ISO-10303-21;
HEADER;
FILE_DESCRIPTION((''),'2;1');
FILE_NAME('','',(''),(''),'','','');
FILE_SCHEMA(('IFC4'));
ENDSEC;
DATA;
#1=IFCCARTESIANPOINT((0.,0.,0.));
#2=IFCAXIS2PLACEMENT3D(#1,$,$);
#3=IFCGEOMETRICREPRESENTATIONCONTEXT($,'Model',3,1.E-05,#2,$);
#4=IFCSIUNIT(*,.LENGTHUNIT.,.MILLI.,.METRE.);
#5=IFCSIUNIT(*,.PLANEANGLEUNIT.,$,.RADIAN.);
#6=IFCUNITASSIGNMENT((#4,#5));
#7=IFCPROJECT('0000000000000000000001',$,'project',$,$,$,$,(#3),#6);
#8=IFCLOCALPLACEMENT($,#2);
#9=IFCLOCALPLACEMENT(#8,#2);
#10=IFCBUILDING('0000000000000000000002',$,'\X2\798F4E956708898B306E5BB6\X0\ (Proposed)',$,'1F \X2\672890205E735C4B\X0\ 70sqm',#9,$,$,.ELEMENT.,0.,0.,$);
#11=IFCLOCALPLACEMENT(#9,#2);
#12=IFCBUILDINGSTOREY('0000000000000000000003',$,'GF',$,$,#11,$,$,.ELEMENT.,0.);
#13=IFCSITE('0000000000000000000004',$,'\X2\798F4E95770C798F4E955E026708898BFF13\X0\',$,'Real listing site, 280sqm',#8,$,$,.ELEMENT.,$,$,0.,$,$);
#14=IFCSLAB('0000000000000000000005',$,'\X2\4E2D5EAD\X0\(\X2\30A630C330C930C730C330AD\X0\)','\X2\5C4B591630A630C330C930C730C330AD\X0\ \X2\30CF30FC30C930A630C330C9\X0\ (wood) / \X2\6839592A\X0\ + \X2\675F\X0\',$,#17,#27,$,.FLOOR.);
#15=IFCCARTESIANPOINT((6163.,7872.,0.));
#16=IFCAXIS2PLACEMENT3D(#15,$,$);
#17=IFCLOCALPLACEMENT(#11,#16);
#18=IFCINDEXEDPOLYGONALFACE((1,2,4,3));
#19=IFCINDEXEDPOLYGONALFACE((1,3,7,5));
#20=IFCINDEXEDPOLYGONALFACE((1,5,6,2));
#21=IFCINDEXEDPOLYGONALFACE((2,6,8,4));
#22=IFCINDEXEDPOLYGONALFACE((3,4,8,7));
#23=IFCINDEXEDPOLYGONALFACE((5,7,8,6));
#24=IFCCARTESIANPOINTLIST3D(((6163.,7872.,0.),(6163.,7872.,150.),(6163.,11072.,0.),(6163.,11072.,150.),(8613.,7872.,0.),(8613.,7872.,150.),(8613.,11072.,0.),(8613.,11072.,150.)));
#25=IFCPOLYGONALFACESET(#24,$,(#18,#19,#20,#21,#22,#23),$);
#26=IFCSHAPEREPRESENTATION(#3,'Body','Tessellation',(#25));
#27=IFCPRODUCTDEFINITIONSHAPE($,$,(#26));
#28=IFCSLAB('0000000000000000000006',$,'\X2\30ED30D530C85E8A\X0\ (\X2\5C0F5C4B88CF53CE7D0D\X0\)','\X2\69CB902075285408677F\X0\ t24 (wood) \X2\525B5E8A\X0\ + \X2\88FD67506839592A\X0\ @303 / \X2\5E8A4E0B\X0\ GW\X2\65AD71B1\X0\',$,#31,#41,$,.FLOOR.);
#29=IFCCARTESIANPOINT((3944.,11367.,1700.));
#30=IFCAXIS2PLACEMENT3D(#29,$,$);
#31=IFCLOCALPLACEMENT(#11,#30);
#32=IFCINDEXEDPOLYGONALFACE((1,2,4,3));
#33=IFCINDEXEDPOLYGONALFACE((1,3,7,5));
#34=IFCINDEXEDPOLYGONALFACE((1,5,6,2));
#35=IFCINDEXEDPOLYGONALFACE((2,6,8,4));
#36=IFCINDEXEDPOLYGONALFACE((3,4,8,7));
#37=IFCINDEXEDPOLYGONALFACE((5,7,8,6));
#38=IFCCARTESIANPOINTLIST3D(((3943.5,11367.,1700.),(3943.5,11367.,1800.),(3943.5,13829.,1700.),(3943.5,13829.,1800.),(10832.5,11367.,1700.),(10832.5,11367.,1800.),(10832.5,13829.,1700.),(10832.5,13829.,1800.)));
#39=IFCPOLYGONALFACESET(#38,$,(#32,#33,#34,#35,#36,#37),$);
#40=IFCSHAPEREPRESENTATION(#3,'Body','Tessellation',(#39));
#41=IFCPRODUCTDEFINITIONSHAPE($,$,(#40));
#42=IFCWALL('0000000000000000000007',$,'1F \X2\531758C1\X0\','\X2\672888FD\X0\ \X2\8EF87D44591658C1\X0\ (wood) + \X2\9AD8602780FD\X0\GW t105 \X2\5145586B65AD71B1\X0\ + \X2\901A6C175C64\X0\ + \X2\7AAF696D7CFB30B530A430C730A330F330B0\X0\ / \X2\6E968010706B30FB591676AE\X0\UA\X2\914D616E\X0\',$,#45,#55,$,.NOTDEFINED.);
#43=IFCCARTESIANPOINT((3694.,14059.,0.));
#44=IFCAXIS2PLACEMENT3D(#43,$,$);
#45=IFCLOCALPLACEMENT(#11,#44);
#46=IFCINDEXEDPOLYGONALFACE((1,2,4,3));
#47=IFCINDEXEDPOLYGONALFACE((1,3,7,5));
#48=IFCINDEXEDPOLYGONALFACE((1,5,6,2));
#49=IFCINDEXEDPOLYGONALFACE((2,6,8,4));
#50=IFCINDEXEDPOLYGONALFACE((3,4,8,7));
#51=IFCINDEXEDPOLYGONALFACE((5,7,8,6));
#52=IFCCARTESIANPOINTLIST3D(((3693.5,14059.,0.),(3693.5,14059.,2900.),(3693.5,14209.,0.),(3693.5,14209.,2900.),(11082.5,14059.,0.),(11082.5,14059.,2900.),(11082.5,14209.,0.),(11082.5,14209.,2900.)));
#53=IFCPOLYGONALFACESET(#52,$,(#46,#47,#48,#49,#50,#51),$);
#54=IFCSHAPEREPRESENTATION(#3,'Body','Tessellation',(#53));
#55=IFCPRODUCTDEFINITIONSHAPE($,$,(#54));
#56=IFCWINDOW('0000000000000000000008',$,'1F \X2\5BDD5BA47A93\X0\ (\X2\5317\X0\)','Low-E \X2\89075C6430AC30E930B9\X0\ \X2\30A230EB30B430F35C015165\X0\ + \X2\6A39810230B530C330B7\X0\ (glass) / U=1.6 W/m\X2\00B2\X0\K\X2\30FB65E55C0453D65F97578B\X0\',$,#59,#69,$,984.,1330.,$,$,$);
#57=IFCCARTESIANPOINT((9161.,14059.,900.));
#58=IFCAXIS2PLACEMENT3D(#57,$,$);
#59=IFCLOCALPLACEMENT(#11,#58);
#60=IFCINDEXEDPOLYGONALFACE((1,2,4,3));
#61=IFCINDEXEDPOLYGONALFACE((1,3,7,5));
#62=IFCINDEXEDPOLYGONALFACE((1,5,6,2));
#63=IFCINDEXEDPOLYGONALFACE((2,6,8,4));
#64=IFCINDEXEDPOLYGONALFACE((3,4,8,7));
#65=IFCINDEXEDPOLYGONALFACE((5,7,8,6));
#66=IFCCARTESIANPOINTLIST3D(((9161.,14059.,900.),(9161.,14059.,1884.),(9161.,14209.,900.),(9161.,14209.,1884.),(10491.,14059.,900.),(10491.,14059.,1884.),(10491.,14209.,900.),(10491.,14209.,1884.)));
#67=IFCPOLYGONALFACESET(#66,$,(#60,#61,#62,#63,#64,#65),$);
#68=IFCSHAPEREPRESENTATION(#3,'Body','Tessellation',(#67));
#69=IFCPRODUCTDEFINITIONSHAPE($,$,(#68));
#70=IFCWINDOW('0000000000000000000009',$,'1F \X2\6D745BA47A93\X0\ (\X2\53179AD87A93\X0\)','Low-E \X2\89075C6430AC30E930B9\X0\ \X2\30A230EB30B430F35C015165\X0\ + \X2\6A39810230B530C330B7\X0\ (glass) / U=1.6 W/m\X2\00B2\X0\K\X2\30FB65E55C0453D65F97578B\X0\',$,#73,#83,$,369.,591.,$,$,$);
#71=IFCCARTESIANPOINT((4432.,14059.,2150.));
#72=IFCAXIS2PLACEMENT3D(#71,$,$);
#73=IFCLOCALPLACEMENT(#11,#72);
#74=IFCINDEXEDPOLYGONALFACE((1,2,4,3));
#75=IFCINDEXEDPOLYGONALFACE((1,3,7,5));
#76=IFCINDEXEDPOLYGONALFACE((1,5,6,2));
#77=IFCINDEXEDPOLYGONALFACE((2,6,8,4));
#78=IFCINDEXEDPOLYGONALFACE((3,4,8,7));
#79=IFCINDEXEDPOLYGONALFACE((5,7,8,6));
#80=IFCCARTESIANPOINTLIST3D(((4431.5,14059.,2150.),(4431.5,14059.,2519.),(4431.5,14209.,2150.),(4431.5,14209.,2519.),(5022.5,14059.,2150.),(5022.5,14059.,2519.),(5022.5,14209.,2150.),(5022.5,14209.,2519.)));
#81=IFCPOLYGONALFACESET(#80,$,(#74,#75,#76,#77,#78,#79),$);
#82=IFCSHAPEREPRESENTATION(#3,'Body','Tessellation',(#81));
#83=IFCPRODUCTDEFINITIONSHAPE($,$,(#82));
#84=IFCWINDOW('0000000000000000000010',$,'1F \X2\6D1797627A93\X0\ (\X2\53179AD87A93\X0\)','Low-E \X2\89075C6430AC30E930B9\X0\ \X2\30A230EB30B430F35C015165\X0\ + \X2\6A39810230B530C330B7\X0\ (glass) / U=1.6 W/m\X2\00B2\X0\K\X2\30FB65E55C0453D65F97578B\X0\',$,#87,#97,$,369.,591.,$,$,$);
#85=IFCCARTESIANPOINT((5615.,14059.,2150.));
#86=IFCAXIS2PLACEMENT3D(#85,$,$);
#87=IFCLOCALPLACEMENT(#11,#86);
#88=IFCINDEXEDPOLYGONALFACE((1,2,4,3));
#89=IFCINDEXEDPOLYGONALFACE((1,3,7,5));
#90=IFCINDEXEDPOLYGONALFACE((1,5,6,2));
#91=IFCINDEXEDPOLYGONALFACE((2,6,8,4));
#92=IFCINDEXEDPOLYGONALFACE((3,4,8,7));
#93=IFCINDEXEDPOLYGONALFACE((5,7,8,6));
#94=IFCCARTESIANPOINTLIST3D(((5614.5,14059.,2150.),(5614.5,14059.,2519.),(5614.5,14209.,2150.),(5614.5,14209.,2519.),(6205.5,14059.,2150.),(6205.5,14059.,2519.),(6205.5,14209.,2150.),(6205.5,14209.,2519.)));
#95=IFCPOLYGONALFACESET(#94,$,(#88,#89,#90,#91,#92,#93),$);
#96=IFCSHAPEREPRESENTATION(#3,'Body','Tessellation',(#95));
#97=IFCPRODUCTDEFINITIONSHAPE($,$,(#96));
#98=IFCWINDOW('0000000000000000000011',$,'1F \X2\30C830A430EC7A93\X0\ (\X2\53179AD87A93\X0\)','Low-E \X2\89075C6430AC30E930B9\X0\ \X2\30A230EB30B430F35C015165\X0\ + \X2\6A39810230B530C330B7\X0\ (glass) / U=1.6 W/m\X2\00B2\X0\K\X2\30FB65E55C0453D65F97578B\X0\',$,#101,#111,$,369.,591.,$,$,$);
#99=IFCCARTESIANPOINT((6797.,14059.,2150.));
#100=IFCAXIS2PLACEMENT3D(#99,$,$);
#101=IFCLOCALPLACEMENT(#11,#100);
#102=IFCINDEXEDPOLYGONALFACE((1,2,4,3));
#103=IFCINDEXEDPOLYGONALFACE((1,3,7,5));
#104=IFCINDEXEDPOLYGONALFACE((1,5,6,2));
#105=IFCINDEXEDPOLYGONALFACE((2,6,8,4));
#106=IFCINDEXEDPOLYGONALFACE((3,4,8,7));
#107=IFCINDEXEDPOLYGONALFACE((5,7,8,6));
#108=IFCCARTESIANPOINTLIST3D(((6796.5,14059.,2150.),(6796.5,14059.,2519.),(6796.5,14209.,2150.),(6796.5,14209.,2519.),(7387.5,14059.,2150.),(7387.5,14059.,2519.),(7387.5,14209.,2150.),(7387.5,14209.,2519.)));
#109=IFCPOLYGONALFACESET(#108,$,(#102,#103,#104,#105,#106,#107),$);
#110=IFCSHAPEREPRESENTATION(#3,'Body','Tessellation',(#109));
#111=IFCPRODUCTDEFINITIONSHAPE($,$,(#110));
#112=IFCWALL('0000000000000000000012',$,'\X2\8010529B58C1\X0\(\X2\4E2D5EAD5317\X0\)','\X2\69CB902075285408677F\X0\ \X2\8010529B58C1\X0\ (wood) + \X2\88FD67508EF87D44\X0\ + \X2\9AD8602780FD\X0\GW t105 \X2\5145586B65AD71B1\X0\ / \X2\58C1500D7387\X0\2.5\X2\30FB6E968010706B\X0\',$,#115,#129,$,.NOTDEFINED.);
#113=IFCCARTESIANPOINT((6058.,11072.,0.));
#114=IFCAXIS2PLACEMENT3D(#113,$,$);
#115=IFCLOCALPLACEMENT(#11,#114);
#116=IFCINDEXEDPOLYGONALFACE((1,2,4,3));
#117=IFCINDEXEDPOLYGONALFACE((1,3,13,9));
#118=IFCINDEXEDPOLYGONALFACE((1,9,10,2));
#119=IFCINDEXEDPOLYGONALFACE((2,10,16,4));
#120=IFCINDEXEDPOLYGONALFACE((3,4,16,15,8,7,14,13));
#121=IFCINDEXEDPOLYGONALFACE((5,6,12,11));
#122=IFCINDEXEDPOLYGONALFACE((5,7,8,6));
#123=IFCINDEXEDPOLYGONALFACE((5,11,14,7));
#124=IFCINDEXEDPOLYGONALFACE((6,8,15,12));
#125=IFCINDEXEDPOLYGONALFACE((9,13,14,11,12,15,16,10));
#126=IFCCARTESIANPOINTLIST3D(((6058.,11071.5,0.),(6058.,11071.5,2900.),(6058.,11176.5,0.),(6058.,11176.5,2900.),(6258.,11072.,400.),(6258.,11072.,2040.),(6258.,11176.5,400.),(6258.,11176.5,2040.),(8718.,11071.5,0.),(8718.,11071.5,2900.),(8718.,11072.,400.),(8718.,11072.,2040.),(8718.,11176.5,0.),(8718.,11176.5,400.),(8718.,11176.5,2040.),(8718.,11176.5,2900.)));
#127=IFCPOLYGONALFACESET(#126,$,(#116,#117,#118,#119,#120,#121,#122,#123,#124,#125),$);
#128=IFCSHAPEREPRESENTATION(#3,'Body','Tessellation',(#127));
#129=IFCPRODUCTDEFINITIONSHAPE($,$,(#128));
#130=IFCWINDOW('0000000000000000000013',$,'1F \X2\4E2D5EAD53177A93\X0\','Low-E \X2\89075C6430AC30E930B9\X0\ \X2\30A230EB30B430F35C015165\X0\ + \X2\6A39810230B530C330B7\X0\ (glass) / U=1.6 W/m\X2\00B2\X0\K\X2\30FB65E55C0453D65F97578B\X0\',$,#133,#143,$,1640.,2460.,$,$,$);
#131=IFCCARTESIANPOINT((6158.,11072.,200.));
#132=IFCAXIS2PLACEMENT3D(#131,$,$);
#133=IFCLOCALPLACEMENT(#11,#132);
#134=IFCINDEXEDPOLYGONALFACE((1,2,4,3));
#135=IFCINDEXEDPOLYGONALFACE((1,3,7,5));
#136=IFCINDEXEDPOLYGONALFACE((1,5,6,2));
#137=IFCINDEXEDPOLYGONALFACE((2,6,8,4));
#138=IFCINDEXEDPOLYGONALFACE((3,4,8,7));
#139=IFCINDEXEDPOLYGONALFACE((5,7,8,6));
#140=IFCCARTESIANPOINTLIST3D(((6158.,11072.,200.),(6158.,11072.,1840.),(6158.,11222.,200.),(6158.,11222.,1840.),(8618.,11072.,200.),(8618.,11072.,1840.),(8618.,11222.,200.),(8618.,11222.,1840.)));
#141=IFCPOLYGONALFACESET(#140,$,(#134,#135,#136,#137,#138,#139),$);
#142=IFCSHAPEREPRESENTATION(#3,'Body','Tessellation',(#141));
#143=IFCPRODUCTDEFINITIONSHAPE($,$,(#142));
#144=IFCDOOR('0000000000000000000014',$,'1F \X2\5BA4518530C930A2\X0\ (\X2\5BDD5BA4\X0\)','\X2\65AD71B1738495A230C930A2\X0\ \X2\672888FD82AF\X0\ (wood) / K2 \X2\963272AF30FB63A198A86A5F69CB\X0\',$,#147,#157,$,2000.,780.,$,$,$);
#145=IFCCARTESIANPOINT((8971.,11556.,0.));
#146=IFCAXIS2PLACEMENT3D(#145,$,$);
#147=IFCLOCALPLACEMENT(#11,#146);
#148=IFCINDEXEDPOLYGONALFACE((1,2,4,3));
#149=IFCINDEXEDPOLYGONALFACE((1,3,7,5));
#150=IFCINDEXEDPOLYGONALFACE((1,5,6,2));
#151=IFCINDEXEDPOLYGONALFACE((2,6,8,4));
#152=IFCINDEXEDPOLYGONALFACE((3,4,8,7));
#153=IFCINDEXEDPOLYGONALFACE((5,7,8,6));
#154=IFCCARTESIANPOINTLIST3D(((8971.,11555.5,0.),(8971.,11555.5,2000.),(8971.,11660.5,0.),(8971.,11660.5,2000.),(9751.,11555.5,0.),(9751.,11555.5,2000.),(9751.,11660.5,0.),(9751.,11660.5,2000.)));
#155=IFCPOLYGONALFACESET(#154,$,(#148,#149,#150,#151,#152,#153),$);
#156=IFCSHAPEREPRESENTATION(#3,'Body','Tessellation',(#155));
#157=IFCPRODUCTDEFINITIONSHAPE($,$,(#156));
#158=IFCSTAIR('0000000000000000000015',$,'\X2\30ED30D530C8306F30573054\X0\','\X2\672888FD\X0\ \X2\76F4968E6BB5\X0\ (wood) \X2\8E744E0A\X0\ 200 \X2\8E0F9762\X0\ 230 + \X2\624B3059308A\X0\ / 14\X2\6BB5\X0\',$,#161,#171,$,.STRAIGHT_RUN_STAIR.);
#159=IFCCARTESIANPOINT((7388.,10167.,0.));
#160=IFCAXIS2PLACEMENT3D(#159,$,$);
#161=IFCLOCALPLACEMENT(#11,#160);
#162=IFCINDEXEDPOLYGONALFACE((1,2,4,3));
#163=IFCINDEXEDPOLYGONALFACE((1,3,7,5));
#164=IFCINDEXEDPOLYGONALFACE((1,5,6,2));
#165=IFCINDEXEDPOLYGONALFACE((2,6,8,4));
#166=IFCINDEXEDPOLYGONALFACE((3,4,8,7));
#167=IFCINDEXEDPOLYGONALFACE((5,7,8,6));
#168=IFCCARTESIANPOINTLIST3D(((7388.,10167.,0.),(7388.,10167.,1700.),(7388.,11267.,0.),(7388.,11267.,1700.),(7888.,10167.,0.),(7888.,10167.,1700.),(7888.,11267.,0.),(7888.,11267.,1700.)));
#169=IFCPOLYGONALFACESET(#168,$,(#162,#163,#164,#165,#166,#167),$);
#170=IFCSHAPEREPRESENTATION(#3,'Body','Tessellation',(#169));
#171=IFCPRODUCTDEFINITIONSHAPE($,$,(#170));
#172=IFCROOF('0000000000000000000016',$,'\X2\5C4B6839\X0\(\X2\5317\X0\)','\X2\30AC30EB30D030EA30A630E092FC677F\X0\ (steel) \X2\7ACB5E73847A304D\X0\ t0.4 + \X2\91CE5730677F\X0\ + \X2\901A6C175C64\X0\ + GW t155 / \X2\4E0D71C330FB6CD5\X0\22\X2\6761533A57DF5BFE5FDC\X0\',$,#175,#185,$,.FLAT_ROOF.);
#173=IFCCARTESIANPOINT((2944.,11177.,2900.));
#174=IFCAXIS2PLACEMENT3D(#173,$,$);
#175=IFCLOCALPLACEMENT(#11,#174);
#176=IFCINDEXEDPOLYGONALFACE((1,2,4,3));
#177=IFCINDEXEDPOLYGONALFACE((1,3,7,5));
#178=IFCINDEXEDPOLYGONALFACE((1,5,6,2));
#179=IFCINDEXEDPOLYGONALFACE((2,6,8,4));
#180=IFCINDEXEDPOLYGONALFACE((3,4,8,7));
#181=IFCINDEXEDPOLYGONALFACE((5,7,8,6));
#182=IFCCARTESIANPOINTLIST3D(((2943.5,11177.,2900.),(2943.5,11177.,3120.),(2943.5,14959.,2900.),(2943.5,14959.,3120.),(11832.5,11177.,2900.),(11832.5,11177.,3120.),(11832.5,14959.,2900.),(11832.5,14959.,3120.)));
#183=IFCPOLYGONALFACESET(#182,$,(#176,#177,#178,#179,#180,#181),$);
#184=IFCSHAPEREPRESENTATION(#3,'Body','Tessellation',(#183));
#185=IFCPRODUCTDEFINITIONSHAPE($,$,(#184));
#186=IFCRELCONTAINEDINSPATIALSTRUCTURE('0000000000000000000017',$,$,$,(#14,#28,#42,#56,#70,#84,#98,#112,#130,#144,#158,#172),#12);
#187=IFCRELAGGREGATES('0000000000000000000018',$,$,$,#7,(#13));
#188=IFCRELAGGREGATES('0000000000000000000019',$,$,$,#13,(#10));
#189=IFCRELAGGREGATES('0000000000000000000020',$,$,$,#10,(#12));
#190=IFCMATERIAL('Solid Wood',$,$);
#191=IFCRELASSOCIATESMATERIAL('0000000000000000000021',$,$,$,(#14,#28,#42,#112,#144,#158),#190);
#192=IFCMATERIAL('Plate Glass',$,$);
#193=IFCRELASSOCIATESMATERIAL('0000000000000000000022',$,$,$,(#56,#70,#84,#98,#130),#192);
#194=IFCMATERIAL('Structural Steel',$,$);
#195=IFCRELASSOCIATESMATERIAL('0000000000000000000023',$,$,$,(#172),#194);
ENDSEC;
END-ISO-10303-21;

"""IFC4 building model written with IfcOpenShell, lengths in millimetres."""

from ifc_helpers import new_model, si_unit, frame, frame_2d, origin, place, context, project, spatial, rectangle, extrude, material, element, fill, save


model = new_model("IFC4")

# Units and contexts
model_context = context("Model", 3, precision=1e-05, world=origin())
ifc_project = project(units=[si_unit("LENGTHUNIT", "METRE", prefix="MILLI"), si_unit("PLANEANGLEUNIT", "RADIAN")], contexts=[model_context])

# Site, building, storey
site_placement = place(None, origin())
site = spatial("IfcSite", under=ifc_project, at=site_placement, Name="福井県福井市月見３", ObjectType="Real listing site, 280sqm", CompositionType="ELEMENT", RefElevation=0.0)
building_placement = place(site_placement, origin())
building = spatial("IfcBuilding", under=site, at=building_placement, Name="福井月見の家 (Proposed)", ObjectType="1F 木造平屋 70sqm", CompositionType="ELEMENT", ElevationOfRefHeight=0.0, ElevationOfTerrain=0.0)
storey_placement = place(building_placement, origin())
storey = spatial("IfcBuildingStorey", under=building, at=storey_placement, Name="GF", CompositionType="ELEMENT", Elevation=0.0)

# Slabs
ifc_material_1 = material(Name="Solid Wood")
slab_1_placement = place(storey_placement, frame((6163.0, 7872.0, 0.0)))
element("IfcSlab", 1, at=slab_1_placement, inside=storey, material=ifc_material_1, Name="中庭(ウッドデッキ)", Description="屋外ウッドデッキ ハードウッド (wood) / 根太 + 束", PredefinedType="FLOOR", context=model_context, shape_type="SweptSolid", body=[
    extrude(rectangle(XDim=2450.0, YDim=3200.0, at=frame_2d((1225.0, 1600.0))), frame((6163.0, 7872.0, 0.0)), (0.0, 0.0, 1.0), 150.0),
])
slab_2_placement = place(storey_placement, frame((3944.0, 11367.0, 1700.0)))
element("IfcSlab", 2, at=slab_2_placement, inside=storey, material=ifc_material_1, Name="ロフト床 (小屋裏収納)", Description="構造用合板 t24 (wood) 剛床 + 製材根太 @303 / 床下 GW断熱", PredefinedType="FLOOR", context=model_context, shape_type="SweptSolid", body=[
    extrude(rectangle(XDim=6889.0, YDim=2462.0, at=frame_2d((3444.0, 1231.0))), frame((3944.0, 11367.0, 1700.0)), (0.0, 0.0, 1.0), 100.0),
])

# Wall, openings, windows
wall_1_placement = place(storey_placement, frame((3694.0, 14059.0, 0.0)))
wall_1 = element("IfcWall", 3, at=wall_1_placement, inside=storey, material=ifc_material_1, Name="1F 北壁", Description="木製 軸組外壁 (wood) + 高性能GW t105 充填断熱 + 通気層 + 窯業系サイディング / 準耐火・外皮UA配慮", PredefinedType="NOTDEFINED", context=model_context, shape_type="SweptSolid", body=[
    extrude(rectangle(XDim=7389.0, YDim=150.0, at=frame_2d((3694.0, 75.0))), frame((3694.0, 14059.0, 0.0)), (0.0, 0.0, 1.0), 2900.0),
])
opening_1_placement = place(storey_placement, frame((9161.0, 14059.0, 900.0)))
opening_1 = element("IfcOpeningElement", 4, at=opening_1_placement, cuts=wall_1, PredefinedType="NOTDEFINED", context=model_context, shape_type="SweptSolid", body=[
    extrude(rectangle(XDim=1330.0, YDim=150.0, at=frame_2d((665.0, 75.0))), frame((9161.0, 14059.0, 900.0)), (0.0, 0.0, 1.0), 984.0),
])
opening_2_placement = place(storey_placement, frame((4432.0, 14059.0, 2150.0)))
opening_2 = element("IfcOpeningElement", 5, at=opening_2_placement, cuts=wall_1, PredefinedType="NOTDEFINED", context=model_context, shape_type="SweptSolid", body=[
    extrude(rectangle(XDim=591.0, YDim=150.0, at=frame_2d((295.0, 75.0))), frame((4432.0, 14059.0, 2150.0)), (0.0, 0.0, 1.0), 369.0),
])
opening_3_placement = place(storey_placement, frame((5615.0, 14059.0, 2150.0)))
opening_3 = element("IfcOpeningElement", 6, at=opening_3_placement, cuts=wall_1, PredefinedType="NOTDEFINED", context=model_context, shape_type="SweptSolid", body=[
    extrude(rectangle(XDim=591.0, YDim=150.0, at=frame_2d((295.0, 75.0))), frame((5615.0, 14059.0, 2150.0)), (0.0, 0.0, 1.0), 369.0),
])
opening_4_placement = place(storey_placement, frame((6797.0, 14059.0, 2150.0)))
opening_4 = element("IfcOpeningElement", 7, at=opening_4_placement, cuts=wall_1, PredefinedType="NOTDEFINED", context=model_context, shape_type="SweptSolid", body=[
    extrude(rectangle(XDim=591.0, YDim=150.0, at=frame_2d((295.0, 75.0))), frame((6797.0, 14059.0, 2150.0)), (0.0, 0.0, 1.0), 369.0),
])
ifc_material_2 = material(Name="Plate Glass")
window_1_placement = place(storey_placement, frame((9161.0, 14059.0, 900.0)))
window_1 = element("IfcWindow", 8, at=window_1_placement, inside=storey, material=ifc_material_2, Name="1F 寝室窓 (北)", Description="Low-E 複層ガラス アルゴン封入 + 樹脂サッシ (glass) / U=1.6 W/m²K・日射取得型", OverallHeight=984.0, OverallWidth=1330.0, context=model_context, shape_type="SweptSolid", body=[
    extrude(rectangle(XDim=1330.0, YDim=150.0, at=frame_2d((665.0, 75.0))), frame((9161.0, 14059.0, 900.0)), (0.0, 0.0, 1.0), 984.0),
])
fill(opening_1, window_1)
window_2_placement = place(storey_placement, frame((4432.0, 14059.0, 2150.0)))
window_2 = element("IfcWindow", 9, at=window_2_placement, inside=storey, material=ifc_material_2, Name="1F 浴室窓 (北高窓)", Description="Low-E 複層ガラス アルゴン封入 + 樹脂サッシ (glass) / U=1.6 W/m²K・日射取得型", OverallHeight=369.0, OverallWidth=591.0, context=model_context, shape_type="SweptSolid", body=[
    extrude(rectangle(XDim=591.0, YDim=150.0, at=frame_2d((295.0, 75.0))), frame((4432.0, 14059.0, 2150.0)), (0.0, 0.0, 1.0), 369.0),
])
fill(opening_2, window_2)
window_3_placement = place(storey_placement, frame((5615.0, 14059.0, 2150.0)))
window_3 = element("IfcWindow", 10, at=window_3_placement, inside=storey, material=ifc_material_2, Name="1F 洗面窓 (北高窓)", Description="Low-E 複層ガラス アルゴン封入 + 樹脂サッシ (glass) / U=1.6 W/m²K・日射取得型", OverallHeight=369.0, OverallWidth=591.0, context=model_context, shape_type="SweptSolid", body=[
    extrude(rectangle(XDim=591.0, YDim=150.0, at=frame_2d((295.0, 75.0))), frame((5615.0, 14059.0, 2150.0)), (0.0, 0.0, 1.0), 369.0),
])
fill(opening_3, window_3)
window_4_placement = place(storey_placement, frame((6797.0, 14059.0, 2150.0)))
window_4 = element("IfcWindow", 11, at=window_4_placement, inside=storey, material=ifc_material_2, Name="1F トイレ窓 (北高窓)", Description="Low-E 複層ガラス アルゴン封入 + 樹脂サッシ (glass) / U=1.6 W/m²K・日射取得型", OverallHeight=369.0, OverallWidth=591.0, context=model_context, shape_type="SweptSolid", body=[
    extrude(rectangle(XDim=591.0, YDim=150.0, at=frame_2d((295.0, 75.0))), frame((6797.0, 14059.0, 2150.0)), (0.0, 0.0, 1.0), 369.0),
])
fill(opening_4, window_4)

# Wall, opening, window
wall_2_placement = place(storey_placement, frame((6058.0, 11072.0, 0.0)))
wall_2 = element("IfcWall", 12, at=wall_2_placement, inside=storey, material=ifc_material_1, Name="耐力壁(中庭北)", Description="構造用合板 耐力壁 (wood) + 製材軸組 + 高性能GW t105 充填断熱 / 壁倍率2.5・準耐火", PredefinedType="NOTDEFINED", context=model_context, shape_type="SweptSolid", body=[
    extrude(rectangle(XDim=2660.0, YDim=105.0, at=frame_2d((1330.0, 52.0))), frame((6058.0, 11072.0, 0.0)), (0.0, 0.0, 1.0), 2900.0),
])
opening_5_placement = place(storey_placement, frame((6158.0, 11072.0, 200.0)))
opening_5 = element("IfcOpeningElement", 13, at=opening_5_placement, cuts=wall_2, PredefinedType="NOTDEFINED", context=model_context, shape_type="SweptSolid", body=[
    extrude(rectangle(XDim=2460.0, YDim=150.0, at=frame_2d((1230.0, 75.0))), frame((6158.0, 11072.0, 200.0)), (0.0, 0.0, 1.0), 1640.0),
])
window_5_placement = place(storey_placement, frame((6158.0, 11072.0, 200.0)))
window_5 = element("IfcWindow", 14, at=window_5_placement, inside=storey, material=ifc_material_2, Name="1F 中庭北窓", Description="Low-E 複層ガラス アルゴン封入 + 樹脂サッシ (glass) / U=1.6 W/m²K・日射取得型", OverallHeight=1640.0, OverallWidth=2460.0, context=model_context, shape_type="SweptSolid", body=[
    extrude(rectangle(XDim=2460.0, YDim=150.0, at=frame_2d((1230.0, 75.0))), frame((6158.0, 11072.0, 200.0)), (0.0, 0.0, 1.0), 1640.0),
])
fill(opening_5, window_5)

# Door
door_1_placement = place(storey_placement, frame((8971.0, 11556.0, 0.0)))
element("IfcDoor", 15, at=door_1_placement, inside=storey, material=ifc_material_1, Name="1F 室内ドア (寝室)", Description="断熱玄関ドア 木製芯 (wood) / K2 防犯・採風機構", OverallHeight=2000.0, OverallWidth=780.0, context=model_context, shape_type="SweptSolid", body=[
    extrude(rectangle(XDim=780.0, YDim=105.0, at=frame_2d((390.0, 52.0))), frame((8971.0, 11556.0, 0.0)), (0.0, 0.0, 1.0), 2000.0),
])

# Stair
stair_placement = place(storey_placement, frame((7388.0, 10167.0, 0.0)))
element("IfcStair", 16, at=stair_placement, inside=storey, material=ifc_material_1, Name="ロフトはしご", Description="木製 直階段 (wood) 蹴上 200 踏面 230 + 手すり / 14段", PredefinedType="STRAIGHT_RUN_STAIR", context=model_context, shape_type="SweptSolid", body=[
    extrude(rectangle(XDim=500.0, YDim=1100.0, at=frame_2d((250.0, 550.0))), frame((7388.0, 10167.0, 0.0)), (0.0, 0.0, 1.0), 1700.0),
])

# Roof
ifc_material_3 = material(Name="Structural Steel")
roof_1_placement = place(storey_placement, frame((2944.0, 11177.0, 2900.0)))
element("IfcRoof", 17, at=roof_1_placement, inside=storey, material=ifc_material_3, Name="屋根(北)", Description="ガルバリウム鋼板 (steel) 立平葺き t0.4 + 野地板 + 通気層 + GW t155 / 不燃・法22条区域対応", PredefinedType="FLAT_ROOF", context=model_context, shape_type="SweptSolid", body=[
    extrude(rectangle(XDim=8889.0, YDim=3782.0, at=frame_2d((4444.0, 1891.0))), frame((2944.0, 11177.0, 2900.0)), (0.0, 0.0, 1.0), 220.0),
])

save(model, "model.ifc")
